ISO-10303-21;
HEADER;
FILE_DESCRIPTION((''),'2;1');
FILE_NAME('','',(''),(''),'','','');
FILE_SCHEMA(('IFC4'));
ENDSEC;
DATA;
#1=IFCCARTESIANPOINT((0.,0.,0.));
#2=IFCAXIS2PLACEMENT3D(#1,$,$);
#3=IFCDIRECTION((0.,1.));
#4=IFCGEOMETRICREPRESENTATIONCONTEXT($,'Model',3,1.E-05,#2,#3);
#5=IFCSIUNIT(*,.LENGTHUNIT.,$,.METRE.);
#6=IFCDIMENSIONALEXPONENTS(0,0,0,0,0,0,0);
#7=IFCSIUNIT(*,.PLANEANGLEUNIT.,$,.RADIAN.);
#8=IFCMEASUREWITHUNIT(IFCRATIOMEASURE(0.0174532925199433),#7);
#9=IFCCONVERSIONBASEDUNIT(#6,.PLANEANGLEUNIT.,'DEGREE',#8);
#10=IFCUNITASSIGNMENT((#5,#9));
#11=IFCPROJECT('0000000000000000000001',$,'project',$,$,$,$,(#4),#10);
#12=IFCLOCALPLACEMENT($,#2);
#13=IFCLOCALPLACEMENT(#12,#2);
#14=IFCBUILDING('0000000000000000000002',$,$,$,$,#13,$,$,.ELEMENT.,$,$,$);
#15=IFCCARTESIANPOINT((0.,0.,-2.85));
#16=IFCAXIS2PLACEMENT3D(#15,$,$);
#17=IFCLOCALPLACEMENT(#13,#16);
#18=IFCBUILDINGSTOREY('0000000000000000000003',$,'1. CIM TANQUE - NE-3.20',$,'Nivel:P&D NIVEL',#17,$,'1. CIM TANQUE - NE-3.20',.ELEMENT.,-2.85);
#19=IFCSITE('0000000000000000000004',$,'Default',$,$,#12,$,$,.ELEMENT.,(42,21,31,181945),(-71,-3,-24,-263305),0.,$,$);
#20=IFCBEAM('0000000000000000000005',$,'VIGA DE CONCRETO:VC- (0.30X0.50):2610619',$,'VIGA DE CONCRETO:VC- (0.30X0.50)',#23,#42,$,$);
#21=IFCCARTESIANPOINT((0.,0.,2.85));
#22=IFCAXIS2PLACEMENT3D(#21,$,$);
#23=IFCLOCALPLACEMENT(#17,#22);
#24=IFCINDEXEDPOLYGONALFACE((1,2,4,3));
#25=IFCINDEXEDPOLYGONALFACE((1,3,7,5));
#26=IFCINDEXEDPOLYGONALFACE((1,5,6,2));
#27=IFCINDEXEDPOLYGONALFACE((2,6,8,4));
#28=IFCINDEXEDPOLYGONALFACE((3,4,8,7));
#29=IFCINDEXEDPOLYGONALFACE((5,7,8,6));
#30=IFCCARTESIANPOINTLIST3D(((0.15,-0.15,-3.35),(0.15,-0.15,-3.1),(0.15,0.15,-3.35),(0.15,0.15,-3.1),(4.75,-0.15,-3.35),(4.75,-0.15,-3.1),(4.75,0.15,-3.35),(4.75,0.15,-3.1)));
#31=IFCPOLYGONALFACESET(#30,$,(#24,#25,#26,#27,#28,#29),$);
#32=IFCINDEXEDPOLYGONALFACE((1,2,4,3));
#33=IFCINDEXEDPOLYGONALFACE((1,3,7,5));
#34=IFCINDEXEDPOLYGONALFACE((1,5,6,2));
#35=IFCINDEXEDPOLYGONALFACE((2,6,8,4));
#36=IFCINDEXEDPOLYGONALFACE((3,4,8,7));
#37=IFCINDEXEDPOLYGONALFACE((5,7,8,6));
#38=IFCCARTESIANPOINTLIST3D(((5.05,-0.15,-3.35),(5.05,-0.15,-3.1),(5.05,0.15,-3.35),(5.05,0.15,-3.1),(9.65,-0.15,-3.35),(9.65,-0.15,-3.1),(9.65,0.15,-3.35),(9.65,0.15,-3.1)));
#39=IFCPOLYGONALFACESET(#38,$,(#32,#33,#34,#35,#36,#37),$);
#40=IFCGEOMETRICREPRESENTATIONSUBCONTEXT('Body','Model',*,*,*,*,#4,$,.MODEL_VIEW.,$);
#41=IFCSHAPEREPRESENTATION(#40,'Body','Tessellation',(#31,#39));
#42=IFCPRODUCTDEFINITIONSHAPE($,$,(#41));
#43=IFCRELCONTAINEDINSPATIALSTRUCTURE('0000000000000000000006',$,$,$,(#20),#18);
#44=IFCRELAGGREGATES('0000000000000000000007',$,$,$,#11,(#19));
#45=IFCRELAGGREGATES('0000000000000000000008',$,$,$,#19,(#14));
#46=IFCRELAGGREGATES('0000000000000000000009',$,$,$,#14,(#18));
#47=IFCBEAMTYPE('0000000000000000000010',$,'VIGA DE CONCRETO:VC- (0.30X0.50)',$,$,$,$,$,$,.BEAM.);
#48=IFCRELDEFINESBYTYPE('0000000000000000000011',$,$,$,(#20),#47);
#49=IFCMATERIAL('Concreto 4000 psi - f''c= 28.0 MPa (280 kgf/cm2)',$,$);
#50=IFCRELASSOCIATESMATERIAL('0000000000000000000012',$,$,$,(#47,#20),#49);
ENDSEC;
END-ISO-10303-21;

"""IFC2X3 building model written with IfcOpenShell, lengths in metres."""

from ifc_helpers import new_model, entity, si_unit, converted_unit, direction, frame, frame_2d, origin, place, context, subcontext, project, spatial, rectangle, extrude, source, transform, mapped, material, type_object, type_shapes, element, save


model = new_model("IFC2X3")

# Units and contexts
model_context = context("Model", 3, precision=1e-05, world=origin(), true_north=direction((0.0, 1.0)))
body_context = subcontext(model_context, "Body", "Model", "MODEL_VIEW")
ifc_project = project(units=[si_unit("LENGTHUNIT", "METRE"), converted_unit("PLANEANGLEUNIT", "DEGREE", entity("IfcRatioMeasure", 0.0174532925199433), si_unit("PLANEANGLEUNIT", "RADIAN"), dimensions=[0, 0, 0, 0, 0, 0, 0])], contexts=[model_context])

# Site, building, storey
site_placement = place(None, origin())
site = spatial("IfcSite", under=ifc_project, at=site_placement, Name="Default", CompositionType="ELEMENT", RefLatitude=(42, 21, 31, 181945), RefLongitude=(-71, -3, -24, -263305), RefElevation=0.0)
building_placement = place(site_placement, origin())
building = spatial("IfcBuilding", under=site, at=building_placement, CompositionType="ELEMENT")
storey_placement = place(building_placement, frame((0.0, 0.0, -2.85)))
storey = spatial("IfcBuildingStorey", under=building, at=storey_placement, Name="1. CIM TANQUE - NE-3.20", ObjectType="Nivel:P&D NIVEL", LongName="1. CIM TANQUE - NE-3.20", CompositionType="ELEMENT", Elevation=-2.85)

# Beam
ifc_material = material(Name="Concreto 4000 psi - f'c= 28.0 MPa (280 kgf/cm2)")
beam_type_1 = type_object("IfcBeamType", Name="VIGA DE CONCRETO:VC- (0.30X0.50)", PredefinedType="BEAM", material=ifc_material)
shared_shape_1 = source(origin(), body_context, "Body", "SweptSolid", [
    extrude(rectangle(XDim=0.25, YDim=0.3, at=frame_2d((0.0, 0.0), x_axis=(1.0, 0.0))), frame((0.15, 0.0, -3.225), z_axis=(1.0, 0.0, 0.0), x_axis=(0.0, 0.0, -1.0)), (0.0, 0.0, 1.0), 4.6),
    extrude(rectangle(XDim=0.25, YDim=0.3, at=frame_2d((0.0, 0.0), x_axis=(1.0, 0.0))), frame((5.05, 0.0, -3.225), z_axis=(1.0, 0.0, 0.0), x_axis=(0.0, 0.0, -1.0)), (0.0, 0.0, 1.0), 4.6),
])
type_shapes(beam_type_1, [shared_shape_1])
beam_1_placement = place(storey_placement, frame((0.0, 0.0, 2.85)))
element("IfcBeam", 1, at=beam_1_placement, inside=storey, type_object=beam_type_1, material=ifc_material, Name="VIGA DE CONCRETO:VC- (0.30X0.50):2610619", ObjectType="VIGA DE CONCRETO:VC- (0.30X0.50)", context=body_context, shape_type="MappedRepresentation", body=[
    mapped(shared_shape_1, transform((0.0, 0.0, 0.0), scale=1.0)),
])

save(model, "model.ifc")
